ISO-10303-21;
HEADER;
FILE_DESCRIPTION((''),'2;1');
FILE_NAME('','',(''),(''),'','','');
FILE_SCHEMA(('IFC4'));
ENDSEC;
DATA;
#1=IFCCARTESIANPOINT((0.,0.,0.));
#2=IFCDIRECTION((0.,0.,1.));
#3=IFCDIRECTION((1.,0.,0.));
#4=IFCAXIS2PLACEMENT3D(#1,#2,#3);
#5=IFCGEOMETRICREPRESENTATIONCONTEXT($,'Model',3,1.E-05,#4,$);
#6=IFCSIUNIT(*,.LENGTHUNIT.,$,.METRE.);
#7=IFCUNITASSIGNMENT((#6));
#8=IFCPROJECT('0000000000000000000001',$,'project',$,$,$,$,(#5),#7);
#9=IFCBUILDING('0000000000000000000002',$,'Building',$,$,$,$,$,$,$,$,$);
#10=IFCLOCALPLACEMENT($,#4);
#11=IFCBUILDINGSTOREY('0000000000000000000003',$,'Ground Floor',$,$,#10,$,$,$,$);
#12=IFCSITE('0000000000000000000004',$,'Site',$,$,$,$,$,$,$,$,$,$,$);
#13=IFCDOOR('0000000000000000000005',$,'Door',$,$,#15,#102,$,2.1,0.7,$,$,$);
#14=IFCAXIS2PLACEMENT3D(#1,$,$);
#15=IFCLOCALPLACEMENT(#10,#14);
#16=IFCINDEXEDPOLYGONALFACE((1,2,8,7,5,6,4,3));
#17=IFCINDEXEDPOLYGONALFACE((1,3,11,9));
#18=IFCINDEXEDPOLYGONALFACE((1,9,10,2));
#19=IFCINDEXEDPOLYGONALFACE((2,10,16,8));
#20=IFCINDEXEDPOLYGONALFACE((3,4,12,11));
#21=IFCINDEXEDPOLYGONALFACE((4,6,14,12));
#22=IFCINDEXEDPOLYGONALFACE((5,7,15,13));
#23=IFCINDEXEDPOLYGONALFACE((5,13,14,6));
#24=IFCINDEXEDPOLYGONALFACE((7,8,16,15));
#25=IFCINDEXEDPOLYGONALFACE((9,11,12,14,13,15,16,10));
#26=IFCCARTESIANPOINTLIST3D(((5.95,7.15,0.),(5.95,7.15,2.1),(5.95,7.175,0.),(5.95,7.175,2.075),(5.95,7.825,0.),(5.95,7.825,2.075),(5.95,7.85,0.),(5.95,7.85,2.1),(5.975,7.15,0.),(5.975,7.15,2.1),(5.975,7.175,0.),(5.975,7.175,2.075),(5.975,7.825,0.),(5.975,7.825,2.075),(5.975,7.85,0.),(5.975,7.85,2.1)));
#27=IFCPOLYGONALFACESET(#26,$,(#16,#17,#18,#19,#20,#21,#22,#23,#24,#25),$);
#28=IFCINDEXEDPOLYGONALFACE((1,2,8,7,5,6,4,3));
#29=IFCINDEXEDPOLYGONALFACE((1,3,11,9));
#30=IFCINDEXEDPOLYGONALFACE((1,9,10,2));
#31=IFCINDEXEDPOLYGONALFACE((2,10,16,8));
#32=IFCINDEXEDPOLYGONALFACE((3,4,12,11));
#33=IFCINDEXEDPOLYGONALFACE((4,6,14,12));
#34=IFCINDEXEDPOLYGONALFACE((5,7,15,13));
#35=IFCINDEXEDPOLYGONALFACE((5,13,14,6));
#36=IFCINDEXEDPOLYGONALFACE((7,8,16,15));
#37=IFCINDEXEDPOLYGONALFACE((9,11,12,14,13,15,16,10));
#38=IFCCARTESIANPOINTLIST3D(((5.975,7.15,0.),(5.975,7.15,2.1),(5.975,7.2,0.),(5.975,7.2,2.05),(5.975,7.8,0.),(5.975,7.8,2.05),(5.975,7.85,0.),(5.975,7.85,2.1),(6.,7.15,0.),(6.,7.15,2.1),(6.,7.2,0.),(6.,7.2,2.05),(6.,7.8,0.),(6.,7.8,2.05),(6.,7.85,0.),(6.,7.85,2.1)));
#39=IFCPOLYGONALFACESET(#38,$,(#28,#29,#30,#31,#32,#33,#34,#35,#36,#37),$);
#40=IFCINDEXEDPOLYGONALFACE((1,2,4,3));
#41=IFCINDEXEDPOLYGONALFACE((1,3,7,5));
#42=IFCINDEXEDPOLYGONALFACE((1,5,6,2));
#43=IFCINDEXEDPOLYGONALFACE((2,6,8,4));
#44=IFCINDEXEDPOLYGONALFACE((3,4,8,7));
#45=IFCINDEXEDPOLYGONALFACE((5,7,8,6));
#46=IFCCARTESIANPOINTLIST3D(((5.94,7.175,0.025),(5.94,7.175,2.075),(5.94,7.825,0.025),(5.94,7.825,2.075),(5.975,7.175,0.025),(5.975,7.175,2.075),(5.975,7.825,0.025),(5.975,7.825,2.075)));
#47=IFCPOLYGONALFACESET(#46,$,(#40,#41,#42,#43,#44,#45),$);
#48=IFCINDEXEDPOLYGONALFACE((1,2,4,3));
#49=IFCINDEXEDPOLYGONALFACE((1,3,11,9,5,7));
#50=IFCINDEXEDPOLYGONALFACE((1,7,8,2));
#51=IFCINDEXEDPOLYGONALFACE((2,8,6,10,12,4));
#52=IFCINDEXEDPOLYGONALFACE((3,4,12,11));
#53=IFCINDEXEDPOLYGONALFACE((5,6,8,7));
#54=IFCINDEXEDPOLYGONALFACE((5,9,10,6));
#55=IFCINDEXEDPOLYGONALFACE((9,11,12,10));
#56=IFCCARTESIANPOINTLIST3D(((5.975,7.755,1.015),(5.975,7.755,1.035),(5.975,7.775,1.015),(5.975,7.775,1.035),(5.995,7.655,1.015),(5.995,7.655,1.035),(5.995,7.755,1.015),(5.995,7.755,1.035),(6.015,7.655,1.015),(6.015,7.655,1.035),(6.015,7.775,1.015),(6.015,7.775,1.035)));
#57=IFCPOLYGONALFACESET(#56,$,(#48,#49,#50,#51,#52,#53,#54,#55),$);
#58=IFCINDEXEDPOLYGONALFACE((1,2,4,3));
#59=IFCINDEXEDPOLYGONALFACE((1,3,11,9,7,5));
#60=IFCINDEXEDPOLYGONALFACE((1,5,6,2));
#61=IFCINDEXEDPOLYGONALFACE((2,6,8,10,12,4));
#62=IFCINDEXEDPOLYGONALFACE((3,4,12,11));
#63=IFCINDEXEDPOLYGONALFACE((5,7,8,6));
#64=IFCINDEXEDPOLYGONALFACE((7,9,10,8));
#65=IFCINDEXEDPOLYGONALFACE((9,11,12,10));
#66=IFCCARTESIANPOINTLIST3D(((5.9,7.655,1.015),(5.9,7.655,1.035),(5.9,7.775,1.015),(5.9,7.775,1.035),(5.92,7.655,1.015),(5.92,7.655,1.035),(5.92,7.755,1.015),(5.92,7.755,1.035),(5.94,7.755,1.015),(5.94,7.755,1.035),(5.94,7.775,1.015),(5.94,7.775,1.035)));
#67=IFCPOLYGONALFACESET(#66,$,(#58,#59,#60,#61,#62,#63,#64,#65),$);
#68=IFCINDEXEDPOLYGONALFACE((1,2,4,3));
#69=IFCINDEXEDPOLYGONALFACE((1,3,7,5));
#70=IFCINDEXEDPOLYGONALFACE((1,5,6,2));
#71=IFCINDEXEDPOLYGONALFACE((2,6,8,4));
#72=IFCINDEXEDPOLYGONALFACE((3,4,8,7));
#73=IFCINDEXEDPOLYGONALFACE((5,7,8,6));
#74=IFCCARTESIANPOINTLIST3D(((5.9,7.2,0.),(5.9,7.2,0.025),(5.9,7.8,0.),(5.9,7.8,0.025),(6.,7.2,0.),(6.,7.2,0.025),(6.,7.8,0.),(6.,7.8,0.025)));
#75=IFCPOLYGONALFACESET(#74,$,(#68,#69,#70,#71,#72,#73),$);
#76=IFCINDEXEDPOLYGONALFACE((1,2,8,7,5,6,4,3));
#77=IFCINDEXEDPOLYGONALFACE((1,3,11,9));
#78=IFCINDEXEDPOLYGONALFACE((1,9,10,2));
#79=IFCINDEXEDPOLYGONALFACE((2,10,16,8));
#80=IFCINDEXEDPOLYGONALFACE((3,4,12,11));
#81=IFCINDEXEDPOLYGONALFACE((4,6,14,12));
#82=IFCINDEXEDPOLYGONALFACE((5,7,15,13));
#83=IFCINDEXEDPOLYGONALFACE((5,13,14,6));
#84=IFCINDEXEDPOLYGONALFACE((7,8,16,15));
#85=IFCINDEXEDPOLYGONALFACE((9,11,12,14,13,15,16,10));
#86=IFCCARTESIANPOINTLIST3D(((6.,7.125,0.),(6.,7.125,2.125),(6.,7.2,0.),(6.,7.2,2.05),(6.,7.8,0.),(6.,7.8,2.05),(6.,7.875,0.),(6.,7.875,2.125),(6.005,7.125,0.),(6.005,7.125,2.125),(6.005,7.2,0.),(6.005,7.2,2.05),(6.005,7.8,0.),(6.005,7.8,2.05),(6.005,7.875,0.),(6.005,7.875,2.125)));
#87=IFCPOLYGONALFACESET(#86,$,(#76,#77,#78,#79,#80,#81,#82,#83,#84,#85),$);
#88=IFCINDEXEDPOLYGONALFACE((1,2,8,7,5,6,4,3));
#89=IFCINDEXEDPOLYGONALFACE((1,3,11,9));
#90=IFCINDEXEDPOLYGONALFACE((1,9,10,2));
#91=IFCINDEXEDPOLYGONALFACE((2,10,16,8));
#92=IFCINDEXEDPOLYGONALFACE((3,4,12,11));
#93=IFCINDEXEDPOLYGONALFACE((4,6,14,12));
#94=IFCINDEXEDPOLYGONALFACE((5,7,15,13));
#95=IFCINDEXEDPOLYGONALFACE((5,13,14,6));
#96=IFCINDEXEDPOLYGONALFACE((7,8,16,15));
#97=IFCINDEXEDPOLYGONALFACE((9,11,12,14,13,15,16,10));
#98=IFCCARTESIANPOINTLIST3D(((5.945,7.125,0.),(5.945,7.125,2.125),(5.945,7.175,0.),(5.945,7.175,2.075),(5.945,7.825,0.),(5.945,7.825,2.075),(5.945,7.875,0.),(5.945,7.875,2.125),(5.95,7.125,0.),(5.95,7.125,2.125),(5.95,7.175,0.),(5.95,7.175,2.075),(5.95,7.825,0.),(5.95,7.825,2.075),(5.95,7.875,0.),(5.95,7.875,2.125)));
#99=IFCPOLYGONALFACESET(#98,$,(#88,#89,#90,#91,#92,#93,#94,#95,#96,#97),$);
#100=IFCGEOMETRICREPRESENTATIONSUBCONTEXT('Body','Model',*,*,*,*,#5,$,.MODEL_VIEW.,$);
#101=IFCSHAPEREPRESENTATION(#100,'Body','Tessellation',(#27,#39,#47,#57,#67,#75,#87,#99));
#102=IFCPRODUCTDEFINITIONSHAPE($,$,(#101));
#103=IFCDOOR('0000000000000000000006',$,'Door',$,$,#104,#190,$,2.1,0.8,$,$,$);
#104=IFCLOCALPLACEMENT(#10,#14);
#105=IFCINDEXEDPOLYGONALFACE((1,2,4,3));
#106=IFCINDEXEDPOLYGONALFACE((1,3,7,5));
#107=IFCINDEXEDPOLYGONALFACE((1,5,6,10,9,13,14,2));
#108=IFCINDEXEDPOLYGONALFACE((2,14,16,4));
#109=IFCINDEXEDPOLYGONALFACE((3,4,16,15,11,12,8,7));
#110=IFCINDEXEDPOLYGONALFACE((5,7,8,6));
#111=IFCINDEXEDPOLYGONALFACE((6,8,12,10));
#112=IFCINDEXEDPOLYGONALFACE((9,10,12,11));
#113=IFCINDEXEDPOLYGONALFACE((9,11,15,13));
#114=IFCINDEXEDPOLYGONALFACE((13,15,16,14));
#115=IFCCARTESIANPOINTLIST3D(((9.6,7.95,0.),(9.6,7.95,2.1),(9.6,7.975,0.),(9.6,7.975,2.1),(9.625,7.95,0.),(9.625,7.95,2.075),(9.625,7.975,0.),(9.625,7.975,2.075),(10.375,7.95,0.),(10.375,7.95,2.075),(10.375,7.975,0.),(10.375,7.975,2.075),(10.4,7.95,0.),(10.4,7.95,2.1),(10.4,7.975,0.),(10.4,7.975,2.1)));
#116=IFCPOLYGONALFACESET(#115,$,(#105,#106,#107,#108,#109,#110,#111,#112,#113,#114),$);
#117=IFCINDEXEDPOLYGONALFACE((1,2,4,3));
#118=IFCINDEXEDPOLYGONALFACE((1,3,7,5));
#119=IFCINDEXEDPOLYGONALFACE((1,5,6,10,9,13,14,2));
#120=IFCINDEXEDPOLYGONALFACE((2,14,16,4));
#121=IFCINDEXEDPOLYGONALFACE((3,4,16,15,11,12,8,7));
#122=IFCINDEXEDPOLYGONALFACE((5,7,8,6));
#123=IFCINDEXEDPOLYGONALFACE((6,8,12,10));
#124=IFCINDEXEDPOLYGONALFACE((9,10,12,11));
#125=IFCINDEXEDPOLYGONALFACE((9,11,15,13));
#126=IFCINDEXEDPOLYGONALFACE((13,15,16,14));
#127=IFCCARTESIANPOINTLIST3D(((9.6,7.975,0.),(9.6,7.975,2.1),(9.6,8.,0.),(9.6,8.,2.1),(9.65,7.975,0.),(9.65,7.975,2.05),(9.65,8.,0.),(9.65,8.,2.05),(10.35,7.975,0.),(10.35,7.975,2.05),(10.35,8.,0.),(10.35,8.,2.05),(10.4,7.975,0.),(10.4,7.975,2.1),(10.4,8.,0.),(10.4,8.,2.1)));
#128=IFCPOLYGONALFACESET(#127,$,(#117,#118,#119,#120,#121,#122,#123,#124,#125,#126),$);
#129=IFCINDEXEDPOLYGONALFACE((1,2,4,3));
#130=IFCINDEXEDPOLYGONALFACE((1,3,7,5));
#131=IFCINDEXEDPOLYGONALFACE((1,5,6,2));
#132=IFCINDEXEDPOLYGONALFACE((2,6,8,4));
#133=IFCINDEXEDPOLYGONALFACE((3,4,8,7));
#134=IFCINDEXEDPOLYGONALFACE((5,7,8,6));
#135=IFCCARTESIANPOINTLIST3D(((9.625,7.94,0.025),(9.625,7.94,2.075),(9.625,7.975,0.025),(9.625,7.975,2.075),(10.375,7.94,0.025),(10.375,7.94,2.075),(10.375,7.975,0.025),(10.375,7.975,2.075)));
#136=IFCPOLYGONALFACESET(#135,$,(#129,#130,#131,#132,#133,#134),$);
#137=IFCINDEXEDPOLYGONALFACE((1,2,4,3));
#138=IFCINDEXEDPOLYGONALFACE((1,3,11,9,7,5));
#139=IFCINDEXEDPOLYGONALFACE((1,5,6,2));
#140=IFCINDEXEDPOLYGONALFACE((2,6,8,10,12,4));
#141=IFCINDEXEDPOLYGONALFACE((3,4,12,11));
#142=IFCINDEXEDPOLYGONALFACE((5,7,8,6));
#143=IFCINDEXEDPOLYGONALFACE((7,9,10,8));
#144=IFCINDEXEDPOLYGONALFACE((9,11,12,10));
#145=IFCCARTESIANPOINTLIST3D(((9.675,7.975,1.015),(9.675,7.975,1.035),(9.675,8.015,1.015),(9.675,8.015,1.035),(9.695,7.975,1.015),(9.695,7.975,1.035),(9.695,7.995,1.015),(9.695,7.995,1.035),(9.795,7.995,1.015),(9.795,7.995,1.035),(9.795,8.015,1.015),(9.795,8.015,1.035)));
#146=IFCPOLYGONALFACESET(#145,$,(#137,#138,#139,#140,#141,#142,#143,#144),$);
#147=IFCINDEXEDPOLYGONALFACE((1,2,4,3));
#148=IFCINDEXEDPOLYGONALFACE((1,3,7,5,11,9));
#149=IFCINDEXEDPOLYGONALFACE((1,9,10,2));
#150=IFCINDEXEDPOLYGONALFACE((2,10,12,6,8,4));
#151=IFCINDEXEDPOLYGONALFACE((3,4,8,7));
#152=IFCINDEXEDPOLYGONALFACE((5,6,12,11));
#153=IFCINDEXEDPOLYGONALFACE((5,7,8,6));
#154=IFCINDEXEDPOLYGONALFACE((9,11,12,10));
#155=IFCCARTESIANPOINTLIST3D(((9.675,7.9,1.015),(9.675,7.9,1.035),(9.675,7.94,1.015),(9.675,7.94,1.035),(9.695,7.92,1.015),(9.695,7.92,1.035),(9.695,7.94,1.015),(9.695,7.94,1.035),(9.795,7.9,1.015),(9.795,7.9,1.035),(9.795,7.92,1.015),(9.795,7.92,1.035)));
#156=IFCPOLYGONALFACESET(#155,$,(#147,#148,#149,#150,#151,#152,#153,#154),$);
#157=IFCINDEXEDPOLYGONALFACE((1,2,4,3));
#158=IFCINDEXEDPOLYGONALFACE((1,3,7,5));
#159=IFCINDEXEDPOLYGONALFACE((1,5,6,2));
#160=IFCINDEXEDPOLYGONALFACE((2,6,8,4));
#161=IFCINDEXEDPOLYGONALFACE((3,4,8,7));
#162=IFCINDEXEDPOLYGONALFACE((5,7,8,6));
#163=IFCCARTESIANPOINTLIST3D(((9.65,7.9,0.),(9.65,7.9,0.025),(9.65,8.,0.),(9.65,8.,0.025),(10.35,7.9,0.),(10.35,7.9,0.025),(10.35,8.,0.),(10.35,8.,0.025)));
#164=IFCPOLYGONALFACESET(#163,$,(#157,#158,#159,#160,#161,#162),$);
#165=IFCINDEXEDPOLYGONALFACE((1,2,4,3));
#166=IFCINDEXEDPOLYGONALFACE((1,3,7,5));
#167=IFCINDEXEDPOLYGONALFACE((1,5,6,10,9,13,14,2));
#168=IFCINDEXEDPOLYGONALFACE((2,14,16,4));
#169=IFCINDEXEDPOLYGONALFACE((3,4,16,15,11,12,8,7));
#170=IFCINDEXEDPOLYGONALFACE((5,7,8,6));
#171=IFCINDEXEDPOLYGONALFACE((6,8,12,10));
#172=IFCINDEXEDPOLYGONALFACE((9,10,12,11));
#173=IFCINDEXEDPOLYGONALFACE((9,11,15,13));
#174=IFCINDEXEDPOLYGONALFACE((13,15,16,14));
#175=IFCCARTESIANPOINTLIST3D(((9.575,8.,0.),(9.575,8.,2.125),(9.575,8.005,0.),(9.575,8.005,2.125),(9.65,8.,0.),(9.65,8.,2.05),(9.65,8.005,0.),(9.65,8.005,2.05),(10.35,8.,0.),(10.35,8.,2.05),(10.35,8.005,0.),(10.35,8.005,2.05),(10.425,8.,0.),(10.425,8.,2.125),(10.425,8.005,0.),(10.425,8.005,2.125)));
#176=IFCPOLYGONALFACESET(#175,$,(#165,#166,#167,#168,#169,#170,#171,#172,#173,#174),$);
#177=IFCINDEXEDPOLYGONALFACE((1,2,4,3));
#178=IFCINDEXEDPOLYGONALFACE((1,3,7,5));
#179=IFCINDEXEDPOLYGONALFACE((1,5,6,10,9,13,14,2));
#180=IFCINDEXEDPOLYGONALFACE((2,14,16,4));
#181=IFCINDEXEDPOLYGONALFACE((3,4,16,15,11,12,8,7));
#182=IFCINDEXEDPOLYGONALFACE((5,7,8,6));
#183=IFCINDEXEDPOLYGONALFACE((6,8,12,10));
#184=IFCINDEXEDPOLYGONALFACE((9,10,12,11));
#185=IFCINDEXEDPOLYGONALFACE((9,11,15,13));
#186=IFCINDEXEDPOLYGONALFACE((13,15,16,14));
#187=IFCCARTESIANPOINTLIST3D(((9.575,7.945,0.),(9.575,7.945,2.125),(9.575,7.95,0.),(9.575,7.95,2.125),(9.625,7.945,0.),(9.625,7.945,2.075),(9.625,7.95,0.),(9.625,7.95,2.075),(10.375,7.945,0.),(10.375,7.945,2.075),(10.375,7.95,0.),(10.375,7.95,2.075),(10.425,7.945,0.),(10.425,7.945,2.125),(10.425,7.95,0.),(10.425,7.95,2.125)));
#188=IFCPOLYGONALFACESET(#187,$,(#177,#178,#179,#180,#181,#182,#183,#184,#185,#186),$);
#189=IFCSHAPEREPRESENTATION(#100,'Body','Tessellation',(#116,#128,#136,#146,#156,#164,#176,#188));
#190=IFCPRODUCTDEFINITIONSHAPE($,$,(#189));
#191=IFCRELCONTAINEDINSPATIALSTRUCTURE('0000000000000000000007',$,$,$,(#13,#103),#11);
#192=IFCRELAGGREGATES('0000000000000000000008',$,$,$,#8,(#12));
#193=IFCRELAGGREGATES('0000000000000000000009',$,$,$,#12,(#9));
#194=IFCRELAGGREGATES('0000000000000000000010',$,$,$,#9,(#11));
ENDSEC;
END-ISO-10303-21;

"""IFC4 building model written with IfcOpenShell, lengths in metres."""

from ifc_helpers import new_model, si_unit, frame, origin_with_axes, place, context, subcontext, project, spatial, line, indexed_curve, outline, extrude, element, save


model = new_model("IFC4")

# Units and contexts
model_context = context("Model", 3, precision=1e-05, world=origin_with_axes())
body_context = subcontext(model_context, "Body", "Model", "MODEL_VIEW")
ifc_project = project(units=[si_unit("LENGTHUNIT", "METRE")], contexts=[model_context])

# Site, building, storey
site = spatial("IfcSite", under=ifc_project, Name="Site")
building = spatial("IfcBuilding", under=site, Name="Building")
storey_placement = place(None, origin_with_axes())
storey = spatial("IfcBuildingStorey", under=building, at=storey_placement, Name="Ground Floor")

# Doors
door_1_placement = place(storey_placement, frame((6.0, 7.15, 0.0), z_axis=(0.0, 0.0, 1.0), x_axis=(0.0, 1.0, 0.0)))
element("IfcDoor", 1, at=door_1_placement, inside=storey, Name="Door", OverallHeight=2.1, OverallWidth=0.7, context=body_context, shape_type="SweptSolid", body=[
    extrude(outline(indexed_curve([(0.0, 0.0), (0.0, 2.1), (0.7, 2.1), (0.7, 0.0), (0.675, 0.0), (0.675, 2.075), (0.025, 2.075), (0.025, 0.0)], segments=[line(1, 2, 3, 4, 5, 6, 7, 8, 1)])), frame((0.0, 0.025, 0.0), z_axis=(0.0, -1.0, 0.0), x_axis=(1.0, 0.0, 0.0)), (0.0, 0.0, -1.0), 0.025),
    extrude(outline(indexed_curve([(0.0, 0.0), (0.0, 2.1), (0.7, 2.1), (0.7, 0.0), (0.65, 0.0), (0.65, 2.05), (0.05, 2.05), (0.05, 0.0)], segments=[line(1, 2, 3, 4, 5, 6, 7, 8, 1)])), frame((0.0, 0.0, 0.0), z_axis=(0.0, -1.0, 0.0), x_axis=(1.0, 0.0, 0.0)), (0.0, 0.0, -1.0), 0.025),
    extrude(outline(indexed_curve([(0.0, 0.0), (0.65, 0.0), (0.65, 0.035), (0.0, 0.035)], segments=[line(1, 2, 3, 4, 1)])), frame((0.025, 0.025, 0.025), z_axis=(0.0, 0.0, 1.0), x_axis=(1.0, 0.0, 0.0)), (0.0, 0.0, 1.0), 2.05),
    extrude(outline(indexed_curve([(0.0, 0.0), (0.0, -0.04), (-0.12, -0.04), (-0.12, -0.02), (-0.02, -0.02), (-0.02, 0.0)], segments=[line(1, 2, 3, 4, 5, 6, 1)])), frame((0.625, 0.025, 1.015), z_axis=(0.0, 0.0, 1.0), x_axis=(1.0, 0.0, 0.0)), (0.0, 0.0, 1.0), 0.02),
    extrude(outline(indexed_curve([(0.0, 0.0), (0.0, 0.04), (-0.12, 0.04), (-0.12, 0.02), (-0.02, 0.02), (-0.02, 0.0)], segments=[line(1, 2, 3, 4, 5, 6, 1)])), frame((0.625, 0.06, 1.015), z_axis=(0.0, 0.0, 1.0), x_axis=(1.0, 0.0, 0.0)), (0.0, 0.0, 1.0), 0.02),
    extrude(outline(indexed_curve([(0.0, 0.0), (0.6, 0.0), (0.6, 0.1), (0.0, 0.1)], segments=[line(1, 2, 3, 4, 1)])), frame((0.05, 0.0, 0.0), z_axis=(0.0, 0.0, 1.0), x_axis=(1.0, 0.0, 0.0)), (0.0, 0.0, 1.0), 0.025),
    extrude(outline(indexed_curve([(0.0, 0.0), (0.0, 2.125), (0.75, 2.125), (0.75, 0.0), (0.675, 0.0), (0.675, 2.05), (0.075, 2.05), (0.075, 0.0)], segments=[line(1, 2, 3, 4, 5, 6, 7, 8, 1)])), frame((-0.025, -0.005, 0.0), z_axis=(0.0, -1.0, 0.0), x_axis=(1.0, 0.0, 0.0)), (0.0, 0.0, -1.0), 0.005),
    extrude(outline(indexed_curve([(0.0, 0.0), (0.0, 2.125), (0.75, 2.125), (0.75, 0.0), (0.7, 0.0), (0.7, 2.075), (0.05, 2.075), (0.05, 0.0)], segments=[line(1, 2, 3, 4, 5, 6, 7, 8, 1)])), frame((-0.025, 0.05, 0.0), z_axis=(0.0, -1.0, 0.0), x_axis=(1.0, 0.0, 0.0)), (0.0, 0.0, -1.0), 0.005),
])
door_2_placement = place(storey_placement, frame((10.4, 8.0, 0.0), z_axis=(0.0, 0.0, 1.0), x_axis=(-1.0, 0.0, 0.0)))
element("IfcDoor", 2, at=door_2_placement, inside=storey, Name="Door", OverallHeight=2.1, OverallWidth=0.8, context=body_context, shape_type="SweptSolid", body=[
    extrude(outline(indexed_curve([(0.0, 0.0), (0.0, 2.1), (0.8, 2.1), (0.8, 0.0), (0.775, 0.0), (0.775, 2.075), (0.025, 2.075), (0.025, 0.0)], segments=[line(1, 2, 3, 4, 5, 6, 7, 8, 1)])), frame((0.0, 0.025, 0.0), z_axis=(0.0, -1.0, 0.0), x_axis=(1.0, 0.0, 0.0)), (0.0, 0.0, -1.0), 0.025),
    extrude(outline(indexed_curve([(0.0, 0.0), (0.0, 2.1), (0.8, 2.1), (0.8, 0.0), (0.75, 0.0), (0.75, 2.05), (0.05, 2.05), (0.05, 0.0)], segments=[line(1, 2, 3, 4, 5, 6, 7, 8, 1)])), frame((0.0, 0.0, 0.0), z_axis=(0.0, -1.0, 0.0), x_axis=(1.0, 0.0, 0.0)), (0.0, 0.0, -1.0), 0.025),
    extrude(outline(indexed_curve([(0.0, 0.0), (0.75, 0.0), (0.75, 0.035), (0.0, 0.035)], segments=[line(1, 2, 3, 4, 1)])), frame((0.025, 0.025, 0.025), z_axis=(0.0, 0.0, 1.0), x_axis=(1.0, 0.0, 0.0)), (0.0, 0.0, 1.0), 2.05),
    extrude(outline(indexed_curve([(0.0, 0.0), (0.0, -0.04), (-0.12, -0.04), (-0.12, -0.02), (-0.02, -0.02), (-0.02, 0.0)], segments=[line(1, 2, 3, 4, 5, 6, 1)])), frame((0.725, 0.025, 1.015), z_axis=(0.0, 0.0, 1.0), x_axis=(1.0, 0.0, 0.0)), (0.0, 0.0, 1.0), 0.02),
    extrude(outline(indexed_curve([(0.0, 0.0), (0.0, 0.04), (-0.12, 0.04), (-0.12, 0.02), (-0.02, 0.02), (-0.02, 0.0)], segments=[line(1, 2, 3, 4, 5, 6, 1)])), frame((0.725, 0.06, 1.015), z_axis=(0.0, 0.0, 1.0), x_axis=(1.0, 0.0, 0.0)), (0.0, 0.0, 1.0), 0.02),
    extrude(outline(indexed_curve([(0.0, 0.0), (0.7, 0.0), (0.7, 0.1), (0.0, 0.1)], segments=[line(1, 2, 3, 4, 1)])), frame((0.05, 0.0, 0.0), z_axis=(0.0, 0.0, 1.0), x_axis=(1.0, 0.0, 0.0)), (0.0, 0.0, 1.0), 0.025),
    extrude(outline(indexed_curve([(0.0, 0.0), (0.0, 2.125), (0.85, 2.125), (0.85, 0.0), (0.775, 0.0), (0.775, 2.05), (0.075, 2.05), (0.075, 0.0)], segments=[line(1, 2, 3, 4, 5, 6, 7, 8, 1)])), frame((-0.025, -0.005, 0.0), z_axis=(0.0, -1.0, 0.0), x_axis=(1.0, 0.0, 0.0)), (0.0, 0.0, -1.0), 0.005),
    extrude(outline(indexed_curve([(0.0, 0.0), (0.0, 2.125), (0.85, 2.125), (0.85, 0.0), (0.8, 0.0), (0.8, 2.075), (0.05, 2.075), (0.05, 0.0)], segments=[line(1, 2, 3, 4, 5, 6, 7, 8, 1)])), frame((-0.025, 0.05, 0.0), z_axis=(0.0, -1.0, 0.0), x_axis=(1.0, 0.0, 0.0)), (0.0, 0.0, -1.0), 0.005),
])

save(model, "model.ifc")
